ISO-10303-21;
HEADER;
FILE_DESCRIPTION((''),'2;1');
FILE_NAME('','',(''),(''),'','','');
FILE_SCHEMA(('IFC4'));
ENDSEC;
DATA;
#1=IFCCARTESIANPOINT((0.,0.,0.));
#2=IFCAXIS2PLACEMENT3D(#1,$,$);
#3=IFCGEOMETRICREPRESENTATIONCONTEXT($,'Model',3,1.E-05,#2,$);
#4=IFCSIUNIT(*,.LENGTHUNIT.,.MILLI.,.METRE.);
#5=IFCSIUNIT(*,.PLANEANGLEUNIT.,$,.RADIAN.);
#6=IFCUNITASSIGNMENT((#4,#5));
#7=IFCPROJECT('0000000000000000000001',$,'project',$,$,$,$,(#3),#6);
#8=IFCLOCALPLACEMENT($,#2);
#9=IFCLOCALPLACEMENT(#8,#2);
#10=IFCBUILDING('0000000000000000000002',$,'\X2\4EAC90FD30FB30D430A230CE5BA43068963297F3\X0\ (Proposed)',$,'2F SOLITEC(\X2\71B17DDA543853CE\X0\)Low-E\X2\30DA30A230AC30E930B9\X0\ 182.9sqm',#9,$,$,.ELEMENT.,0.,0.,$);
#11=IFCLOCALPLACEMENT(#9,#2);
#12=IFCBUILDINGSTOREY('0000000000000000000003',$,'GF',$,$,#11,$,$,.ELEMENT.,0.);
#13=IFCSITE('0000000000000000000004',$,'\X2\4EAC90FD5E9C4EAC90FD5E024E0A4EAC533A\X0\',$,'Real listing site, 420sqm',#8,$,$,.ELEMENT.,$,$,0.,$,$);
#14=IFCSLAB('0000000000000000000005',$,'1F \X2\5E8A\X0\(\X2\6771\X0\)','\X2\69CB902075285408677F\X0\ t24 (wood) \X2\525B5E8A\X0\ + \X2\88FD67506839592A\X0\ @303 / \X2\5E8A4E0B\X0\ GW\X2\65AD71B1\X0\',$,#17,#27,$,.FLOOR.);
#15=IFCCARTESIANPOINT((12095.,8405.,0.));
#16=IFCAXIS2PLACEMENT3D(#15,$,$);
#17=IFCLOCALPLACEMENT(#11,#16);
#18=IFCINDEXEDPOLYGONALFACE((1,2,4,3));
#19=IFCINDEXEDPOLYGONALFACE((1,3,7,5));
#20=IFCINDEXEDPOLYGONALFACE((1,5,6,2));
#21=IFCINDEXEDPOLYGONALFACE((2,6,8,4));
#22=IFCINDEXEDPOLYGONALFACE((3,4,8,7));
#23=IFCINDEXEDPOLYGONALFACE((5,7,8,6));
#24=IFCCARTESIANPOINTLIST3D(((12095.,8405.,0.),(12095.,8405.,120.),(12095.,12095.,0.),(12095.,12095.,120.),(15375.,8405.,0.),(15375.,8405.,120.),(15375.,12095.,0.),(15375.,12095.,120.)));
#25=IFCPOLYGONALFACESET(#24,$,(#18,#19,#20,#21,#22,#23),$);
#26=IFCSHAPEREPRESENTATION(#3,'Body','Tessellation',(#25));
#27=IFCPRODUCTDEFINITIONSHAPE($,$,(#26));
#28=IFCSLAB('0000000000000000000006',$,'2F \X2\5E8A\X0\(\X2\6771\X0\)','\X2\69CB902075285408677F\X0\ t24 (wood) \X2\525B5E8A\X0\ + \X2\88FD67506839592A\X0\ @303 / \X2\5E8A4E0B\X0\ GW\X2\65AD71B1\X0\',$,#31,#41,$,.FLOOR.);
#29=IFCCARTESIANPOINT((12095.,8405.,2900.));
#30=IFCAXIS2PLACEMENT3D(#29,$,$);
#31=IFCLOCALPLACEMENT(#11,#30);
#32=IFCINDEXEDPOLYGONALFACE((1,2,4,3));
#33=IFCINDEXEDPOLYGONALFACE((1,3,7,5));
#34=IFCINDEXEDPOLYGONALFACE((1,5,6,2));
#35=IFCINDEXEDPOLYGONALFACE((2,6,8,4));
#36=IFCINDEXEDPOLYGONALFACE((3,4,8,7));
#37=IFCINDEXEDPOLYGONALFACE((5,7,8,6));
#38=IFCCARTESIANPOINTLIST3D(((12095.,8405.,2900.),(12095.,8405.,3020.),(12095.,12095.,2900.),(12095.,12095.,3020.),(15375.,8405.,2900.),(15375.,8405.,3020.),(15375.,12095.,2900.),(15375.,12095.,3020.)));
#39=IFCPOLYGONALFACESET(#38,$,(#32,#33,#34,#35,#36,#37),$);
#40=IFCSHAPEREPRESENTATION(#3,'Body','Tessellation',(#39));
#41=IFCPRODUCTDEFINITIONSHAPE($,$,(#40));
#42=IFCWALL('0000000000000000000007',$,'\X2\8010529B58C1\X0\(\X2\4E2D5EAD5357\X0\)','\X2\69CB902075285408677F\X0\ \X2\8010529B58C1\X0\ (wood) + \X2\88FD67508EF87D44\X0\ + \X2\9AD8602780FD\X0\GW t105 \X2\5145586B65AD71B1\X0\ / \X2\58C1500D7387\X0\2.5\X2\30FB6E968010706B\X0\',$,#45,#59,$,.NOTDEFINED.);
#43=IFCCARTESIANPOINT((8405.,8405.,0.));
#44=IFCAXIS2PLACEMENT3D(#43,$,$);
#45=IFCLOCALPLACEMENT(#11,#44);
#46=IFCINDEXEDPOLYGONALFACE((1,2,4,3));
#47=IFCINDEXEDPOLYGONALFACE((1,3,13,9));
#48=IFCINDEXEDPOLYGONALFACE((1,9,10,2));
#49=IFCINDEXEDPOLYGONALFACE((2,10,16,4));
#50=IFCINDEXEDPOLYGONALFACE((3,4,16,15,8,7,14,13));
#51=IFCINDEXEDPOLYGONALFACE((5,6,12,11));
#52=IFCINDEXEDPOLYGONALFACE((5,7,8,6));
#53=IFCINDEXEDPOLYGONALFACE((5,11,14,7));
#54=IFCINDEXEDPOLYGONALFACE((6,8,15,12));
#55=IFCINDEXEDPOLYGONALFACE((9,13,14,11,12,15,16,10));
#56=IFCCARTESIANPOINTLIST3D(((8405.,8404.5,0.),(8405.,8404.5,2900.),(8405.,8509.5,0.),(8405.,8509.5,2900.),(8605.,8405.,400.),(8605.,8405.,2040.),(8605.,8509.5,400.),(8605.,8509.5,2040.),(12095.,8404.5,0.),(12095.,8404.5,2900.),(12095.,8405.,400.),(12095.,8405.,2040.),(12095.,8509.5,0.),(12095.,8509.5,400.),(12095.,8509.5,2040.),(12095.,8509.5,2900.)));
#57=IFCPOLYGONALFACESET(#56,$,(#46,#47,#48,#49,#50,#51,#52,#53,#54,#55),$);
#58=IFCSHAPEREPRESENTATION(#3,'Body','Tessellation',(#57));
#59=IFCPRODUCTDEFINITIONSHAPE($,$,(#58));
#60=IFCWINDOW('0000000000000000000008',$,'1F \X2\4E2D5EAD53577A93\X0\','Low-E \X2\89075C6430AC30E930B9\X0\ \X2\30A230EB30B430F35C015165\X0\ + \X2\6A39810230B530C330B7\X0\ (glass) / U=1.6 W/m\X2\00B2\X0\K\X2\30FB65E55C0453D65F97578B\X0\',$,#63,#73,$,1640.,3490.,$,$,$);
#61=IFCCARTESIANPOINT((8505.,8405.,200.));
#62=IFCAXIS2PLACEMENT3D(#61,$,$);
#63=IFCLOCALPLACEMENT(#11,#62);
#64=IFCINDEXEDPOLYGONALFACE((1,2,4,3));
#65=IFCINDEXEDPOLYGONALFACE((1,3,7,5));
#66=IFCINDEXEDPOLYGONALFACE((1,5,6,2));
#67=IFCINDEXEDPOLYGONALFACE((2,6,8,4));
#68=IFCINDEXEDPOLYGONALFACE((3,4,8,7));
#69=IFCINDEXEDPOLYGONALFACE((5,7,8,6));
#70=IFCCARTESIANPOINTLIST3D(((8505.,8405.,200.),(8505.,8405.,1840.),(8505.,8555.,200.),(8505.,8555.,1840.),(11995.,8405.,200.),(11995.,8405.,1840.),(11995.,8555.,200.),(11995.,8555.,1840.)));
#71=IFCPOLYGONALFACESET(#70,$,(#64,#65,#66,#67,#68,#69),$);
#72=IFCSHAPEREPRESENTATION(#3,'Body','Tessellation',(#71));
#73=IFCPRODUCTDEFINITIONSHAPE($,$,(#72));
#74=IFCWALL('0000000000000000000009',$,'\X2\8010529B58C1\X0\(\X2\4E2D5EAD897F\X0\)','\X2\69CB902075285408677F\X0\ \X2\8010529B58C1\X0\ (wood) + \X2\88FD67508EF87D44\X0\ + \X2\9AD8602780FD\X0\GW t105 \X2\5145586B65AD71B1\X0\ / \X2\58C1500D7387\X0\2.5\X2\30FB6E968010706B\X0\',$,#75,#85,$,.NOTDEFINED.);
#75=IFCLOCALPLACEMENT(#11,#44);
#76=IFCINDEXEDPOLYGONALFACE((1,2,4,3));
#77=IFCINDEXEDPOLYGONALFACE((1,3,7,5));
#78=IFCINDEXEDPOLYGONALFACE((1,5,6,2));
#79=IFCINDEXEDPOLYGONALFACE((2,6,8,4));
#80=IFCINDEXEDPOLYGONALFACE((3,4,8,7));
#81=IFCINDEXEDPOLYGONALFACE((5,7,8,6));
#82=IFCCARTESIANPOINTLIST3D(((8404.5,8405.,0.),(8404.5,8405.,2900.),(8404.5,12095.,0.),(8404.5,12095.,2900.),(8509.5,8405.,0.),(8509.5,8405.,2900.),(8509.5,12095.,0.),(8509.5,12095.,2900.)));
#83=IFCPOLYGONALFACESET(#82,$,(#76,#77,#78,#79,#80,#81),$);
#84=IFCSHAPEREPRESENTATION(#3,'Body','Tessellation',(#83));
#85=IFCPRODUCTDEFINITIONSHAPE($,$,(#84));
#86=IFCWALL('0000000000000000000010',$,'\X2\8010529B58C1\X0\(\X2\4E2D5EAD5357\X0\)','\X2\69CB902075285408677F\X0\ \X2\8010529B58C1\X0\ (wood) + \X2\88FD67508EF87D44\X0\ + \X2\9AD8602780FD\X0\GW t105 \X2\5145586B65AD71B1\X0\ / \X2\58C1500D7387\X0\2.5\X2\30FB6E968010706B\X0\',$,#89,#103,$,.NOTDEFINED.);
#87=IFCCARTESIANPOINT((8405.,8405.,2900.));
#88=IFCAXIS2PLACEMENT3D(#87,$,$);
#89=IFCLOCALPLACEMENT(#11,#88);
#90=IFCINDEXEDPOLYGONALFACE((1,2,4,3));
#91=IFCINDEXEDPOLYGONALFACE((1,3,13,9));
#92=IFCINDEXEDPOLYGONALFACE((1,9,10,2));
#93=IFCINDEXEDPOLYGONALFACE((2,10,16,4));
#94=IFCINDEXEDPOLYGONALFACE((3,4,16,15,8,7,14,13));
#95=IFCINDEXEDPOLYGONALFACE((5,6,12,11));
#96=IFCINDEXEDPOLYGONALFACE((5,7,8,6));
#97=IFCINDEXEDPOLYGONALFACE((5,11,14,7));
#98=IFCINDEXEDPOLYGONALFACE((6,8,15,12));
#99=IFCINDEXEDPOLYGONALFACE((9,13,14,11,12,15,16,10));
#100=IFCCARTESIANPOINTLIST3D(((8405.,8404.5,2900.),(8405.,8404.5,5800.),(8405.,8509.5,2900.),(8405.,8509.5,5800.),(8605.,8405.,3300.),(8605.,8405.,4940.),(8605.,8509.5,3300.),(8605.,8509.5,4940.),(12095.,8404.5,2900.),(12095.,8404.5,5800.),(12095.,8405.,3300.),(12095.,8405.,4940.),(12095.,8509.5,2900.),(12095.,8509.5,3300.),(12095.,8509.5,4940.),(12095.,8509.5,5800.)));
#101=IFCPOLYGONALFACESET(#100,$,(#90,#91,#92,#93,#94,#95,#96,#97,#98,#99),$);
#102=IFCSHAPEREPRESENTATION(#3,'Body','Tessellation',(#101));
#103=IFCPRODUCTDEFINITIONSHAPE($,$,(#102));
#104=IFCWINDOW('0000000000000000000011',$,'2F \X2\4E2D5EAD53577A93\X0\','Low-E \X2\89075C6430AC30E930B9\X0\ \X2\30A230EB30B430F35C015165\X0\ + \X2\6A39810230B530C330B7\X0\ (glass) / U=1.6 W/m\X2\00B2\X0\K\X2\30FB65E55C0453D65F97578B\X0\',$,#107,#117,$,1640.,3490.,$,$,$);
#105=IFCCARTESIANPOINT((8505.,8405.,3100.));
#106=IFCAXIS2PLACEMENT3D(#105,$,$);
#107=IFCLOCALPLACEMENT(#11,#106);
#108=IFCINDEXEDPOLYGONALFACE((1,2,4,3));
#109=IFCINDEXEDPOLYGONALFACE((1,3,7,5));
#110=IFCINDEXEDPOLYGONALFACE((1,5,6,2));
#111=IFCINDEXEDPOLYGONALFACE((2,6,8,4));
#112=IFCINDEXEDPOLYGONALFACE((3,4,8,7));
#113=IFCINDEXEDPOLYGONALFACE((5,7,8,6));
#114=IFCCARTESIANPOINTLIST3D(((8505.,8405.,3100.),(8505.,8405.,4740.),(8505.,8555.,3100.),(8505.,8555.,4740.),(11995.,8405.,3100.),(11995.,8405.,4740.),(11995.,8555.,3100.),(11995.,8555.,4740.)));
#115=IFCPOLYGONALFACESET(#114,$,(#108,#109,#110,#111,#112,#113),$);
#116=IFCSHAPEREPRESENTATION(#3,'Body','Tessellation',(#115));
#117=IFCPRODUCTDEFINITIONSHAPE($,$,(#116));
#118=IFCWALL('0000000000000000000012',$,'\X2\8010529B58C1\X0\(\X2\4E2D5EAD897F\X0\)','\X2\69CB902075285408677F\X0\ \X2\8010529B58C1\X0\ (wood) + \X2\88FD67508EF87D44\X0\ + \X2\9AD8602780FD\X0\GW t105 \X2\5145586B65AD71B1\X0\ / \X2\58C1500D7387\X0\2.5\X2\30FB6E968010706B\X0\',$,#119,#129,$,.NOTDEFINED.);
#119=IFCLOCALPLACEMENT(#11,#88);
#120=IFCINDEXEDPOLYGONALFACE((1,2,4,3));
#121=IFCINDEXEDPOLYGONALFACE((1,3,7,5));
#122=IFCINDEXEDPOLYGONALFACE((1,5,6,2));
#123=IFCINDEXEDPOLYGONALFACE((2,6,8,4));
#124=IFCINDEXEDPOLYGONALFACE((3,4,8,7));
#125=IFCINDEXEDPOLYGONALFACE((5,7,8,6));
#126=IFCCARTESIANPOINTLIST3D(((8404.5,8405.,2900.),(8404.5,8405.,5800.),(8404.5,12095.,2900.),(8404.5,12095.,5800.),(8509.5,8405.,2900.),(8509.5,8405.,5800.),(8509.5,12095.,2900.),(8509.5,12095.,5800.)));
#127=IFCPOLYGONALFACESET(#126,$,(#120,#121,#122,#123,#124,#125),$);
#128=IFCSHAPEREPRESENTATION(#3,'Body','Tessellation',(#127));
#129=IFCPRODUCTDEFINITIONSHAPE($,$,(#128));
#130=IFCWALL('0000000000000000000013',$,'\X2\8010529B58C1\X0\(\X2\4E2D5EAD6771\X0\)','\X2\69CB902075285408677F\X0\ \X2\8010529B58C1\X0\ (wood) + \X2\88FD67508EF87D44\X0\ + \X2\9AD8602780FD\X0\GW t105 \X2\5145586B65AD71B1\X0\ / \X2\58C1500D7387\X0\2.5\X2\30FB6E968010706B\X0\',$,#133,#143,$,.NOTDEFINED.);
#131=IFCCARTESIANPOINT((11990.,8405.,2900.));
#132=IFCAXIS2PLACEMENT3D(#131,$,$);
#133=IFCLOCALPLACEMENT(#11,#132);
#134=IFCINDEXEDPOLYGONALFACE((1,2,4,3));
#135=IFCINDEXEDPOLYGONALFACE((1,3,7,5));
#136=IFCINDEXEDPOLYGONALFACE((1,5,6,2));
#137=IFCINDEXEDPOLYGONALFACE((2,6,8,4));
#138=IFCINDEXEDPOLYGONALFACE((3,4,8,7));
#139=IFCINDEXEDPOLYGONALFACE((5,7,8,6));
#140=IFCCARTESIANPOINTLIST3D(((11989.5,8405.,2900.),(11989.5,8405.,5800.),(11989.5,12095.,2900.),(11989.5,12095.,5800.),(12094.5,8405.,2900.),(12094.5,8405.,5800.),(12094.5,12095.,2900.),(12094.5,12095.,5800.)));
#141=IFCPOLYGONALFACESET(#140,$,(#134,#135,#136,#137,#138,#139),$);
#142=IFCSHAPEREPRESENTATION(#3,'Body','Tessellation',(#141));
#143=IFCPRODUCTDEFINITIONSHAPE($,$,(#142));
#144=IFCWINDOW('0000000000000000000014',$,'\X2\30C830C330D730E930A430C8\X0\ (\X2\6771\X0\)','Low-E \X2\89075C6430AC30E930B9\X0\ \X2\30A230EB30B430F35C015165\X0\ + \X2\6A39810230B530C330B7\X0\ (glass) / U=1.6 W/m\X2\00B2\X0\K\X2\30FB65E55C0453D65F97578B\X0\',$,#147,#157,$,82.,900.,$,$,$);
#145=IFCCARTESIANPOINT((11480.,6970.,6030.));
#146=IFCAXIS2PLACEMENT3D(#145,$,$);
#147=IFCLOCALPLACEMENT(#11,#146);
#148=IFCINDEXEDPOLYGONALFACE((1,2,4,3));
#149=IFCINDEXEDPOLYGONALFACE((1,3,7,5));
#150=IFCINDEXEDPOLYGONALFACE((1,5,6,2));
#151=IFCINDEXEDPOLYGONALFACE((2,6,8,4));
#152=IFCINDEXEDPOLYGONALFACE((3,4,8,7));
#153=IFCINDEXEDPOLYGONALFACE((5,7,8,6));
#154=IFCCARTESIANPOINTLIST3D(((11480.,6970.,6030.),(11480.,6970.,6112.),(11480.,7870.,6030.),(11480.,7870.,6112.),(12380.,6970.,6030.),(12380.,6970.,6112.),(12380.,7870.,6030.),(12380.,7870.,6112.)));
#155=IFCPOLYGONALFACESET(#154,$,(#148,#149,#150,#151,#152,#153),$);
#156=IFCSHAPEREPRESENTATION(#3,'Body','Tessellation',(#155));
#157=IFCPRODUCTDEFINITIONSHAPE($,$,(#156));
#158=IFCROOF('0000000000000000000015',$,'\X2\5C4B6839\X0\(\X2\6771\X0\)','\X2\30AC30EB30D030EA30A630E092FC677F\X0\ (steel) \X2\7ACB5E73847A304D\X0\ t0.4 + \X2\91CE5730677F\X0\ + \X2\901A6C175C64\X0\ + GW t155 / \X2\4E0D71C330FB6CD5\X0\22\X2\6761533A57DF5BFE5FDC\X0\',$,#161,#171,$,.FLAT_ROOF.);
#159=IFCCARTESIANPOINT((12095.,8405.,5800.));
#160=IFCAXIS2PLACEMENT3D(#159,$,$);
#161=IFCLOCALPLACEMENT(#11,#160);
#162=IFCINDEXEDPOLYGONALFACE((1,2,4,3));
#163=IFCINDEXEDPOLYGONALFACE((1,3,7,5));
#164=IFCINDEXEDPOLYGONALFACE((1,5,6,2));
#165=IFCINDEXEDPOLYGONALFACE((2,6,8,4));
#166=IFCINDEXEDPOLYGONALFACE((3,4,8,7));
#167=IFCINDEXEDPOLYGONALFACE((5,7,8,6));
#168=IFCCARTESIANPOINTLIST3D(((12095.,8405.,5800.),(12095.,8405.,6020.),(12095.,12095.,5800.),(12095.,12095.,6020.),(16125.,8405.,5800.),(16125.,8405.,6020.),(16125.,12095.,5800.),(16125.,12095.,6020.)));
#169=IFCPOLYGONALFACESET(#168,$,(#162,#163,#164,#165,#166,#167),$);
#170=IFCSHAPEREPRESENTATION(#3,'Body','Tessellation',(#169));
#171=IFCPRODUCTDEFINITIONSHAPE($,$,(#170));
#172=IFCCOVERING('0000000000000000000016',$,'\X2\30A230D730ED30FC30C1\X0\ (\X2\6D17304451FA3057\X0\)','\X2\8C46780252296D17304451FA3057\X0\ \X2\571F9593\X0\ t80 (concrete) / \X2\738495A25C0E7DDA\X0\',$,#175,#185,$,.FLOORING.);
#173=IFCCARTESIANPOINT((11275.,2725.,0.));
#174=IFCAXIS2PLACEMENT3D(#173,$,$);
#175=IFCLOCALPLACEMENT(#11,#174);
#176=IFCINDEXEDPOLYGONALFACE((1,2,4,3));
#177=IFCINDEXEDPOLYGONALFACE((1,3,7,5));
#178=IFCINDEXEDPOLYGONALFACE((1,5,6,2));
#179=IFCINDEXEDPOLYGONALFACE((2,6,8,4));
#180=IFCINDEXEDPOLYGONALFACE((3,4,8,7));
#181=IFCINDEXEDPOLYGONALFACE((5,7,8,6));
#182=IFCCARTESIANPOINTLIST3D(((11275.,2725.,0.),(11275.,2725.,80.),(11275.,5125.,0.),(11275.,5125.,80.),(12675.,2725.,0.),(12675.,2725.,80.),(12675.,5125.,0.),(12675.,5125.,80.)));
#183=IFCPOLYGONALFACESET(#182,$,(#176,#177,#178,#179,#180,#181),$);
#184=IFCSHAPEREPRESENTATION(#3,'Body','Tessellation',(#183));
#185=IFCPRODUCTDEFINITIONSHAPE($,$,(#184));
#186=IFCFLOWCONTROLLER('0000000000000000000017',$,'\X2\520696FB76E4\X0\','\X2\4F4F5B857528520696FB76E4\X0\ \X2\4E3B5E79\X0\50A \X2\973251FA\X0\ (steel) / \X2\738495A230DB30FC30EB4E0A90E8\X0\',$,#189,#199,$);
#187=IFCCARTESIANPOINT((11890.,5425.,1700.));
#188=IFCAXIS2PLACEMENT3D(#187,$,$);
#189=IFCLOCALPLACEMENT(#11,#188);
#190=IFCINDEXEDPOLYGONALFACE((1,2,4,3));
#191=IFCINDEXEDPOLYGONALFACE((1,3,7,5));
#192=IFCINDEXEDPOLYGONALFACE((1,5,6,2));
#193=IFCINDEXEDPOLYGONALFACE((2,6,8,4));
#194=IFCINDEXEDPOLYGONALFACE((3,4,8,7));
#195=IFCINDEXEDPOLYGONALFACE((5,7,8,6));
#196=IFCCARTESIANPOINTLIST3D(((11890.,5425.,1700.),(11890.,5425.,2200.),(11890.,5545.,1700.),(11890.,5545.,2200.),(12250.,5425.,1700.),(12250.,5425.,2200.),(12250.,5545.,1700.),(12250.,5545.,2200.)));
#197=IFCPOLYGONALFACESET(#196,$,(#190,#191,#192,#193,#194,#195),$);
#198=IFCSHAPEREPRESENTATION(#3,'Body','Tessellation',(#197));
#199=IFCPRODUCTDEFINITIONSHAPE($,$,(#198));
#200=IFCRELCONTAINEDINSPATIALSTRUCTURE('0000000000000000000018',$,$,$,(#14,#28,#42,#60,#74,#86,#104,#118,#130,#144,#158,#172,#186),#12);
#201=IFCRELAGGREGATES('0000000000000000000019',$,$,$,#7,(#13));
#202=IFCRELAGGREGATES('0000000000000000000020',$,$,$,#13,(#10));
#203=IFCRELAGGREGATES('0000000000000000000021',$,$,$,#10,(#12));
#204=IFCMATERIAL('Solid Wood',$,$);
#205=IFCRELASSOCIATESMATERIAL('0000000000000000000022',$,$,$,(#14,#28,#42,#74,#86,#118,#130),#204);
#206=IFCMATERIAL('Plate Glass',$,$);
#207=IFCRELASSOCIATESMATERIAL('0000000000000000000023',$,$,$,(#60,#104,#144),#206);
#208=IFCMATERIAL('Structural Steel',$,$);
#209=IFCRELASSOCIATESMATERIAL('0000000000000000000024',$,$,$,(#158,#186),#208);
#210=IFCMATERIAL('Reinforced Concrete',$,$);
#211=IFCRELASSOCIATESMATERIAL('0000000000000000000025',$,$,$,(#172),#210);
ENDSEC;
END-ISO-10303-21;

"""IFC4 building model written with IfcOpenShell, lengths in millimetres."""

from ifc_helpers import new_model, si_unit, frame, frame_2d, origin, place, context, project, spatial, rectangle, extrude, material, element, fill, save


model = new_model("IFC4")

# Units and contexts
model_context = context("Model", 3, precision=1e-05, world=origin())
ifc_project = project(units=[si_unit("LENGTHUNIT", "METRE", prefix="MILLI"), si_unit("PLANEANGLEUNIT", "RADIAN")], contexts=[model_context])

# Site, building, storey
site_placement = place(None, origin())
site = spatial("IfcSite", under=ifc_project, at=site_placement, Name="京都府京都市上京区", ObjectType="Real listing site, 420sqm", CompositionType="ELEMENT", RefElevation=0.0)
building_placement = place(site_placement, origin())
building = spatial("IfcBuilding", under=site, at=building_placement, Name="京都・ピアノ室と防音 (Proposed)", ObjectType="2F SOLITEC(熱線吸収)Low-Eペアガラス 182.9sqm", CompositionType="ELEMENT", ElevationOfRefHeight=0.0, ElevationOfTerrain=0.0)
storey_placement = place(building_placement, origin())
storey = spatial("IfcBuildingStorey", under=building, at=storey_placement, Name="GF", CompositionType="ELEMENT", Elevation=0.0)

# Shared definitions
ifc_material_1 = material(Name="Solid Wood")

# Slabs
slab_1_placement = place(storey_placement, frame((12095.0, 8405.0, 0.0)))
element("IfcSlab", 1, at=slab_1_placement, inside=storey, material=ifc_material_1, Name="1F 床(東)", Description="構造用合板 t24 (wood) 剛床 + 製材根太 @303 / 床下 GW断熱", PredefinedType="FLOOR", context=model_context, shape_type="SweptSolid", body=[
    extrude(rectangle(XDim=3280.0, YDim=3690.0, at=frame_2d((1640.0, 1845.0))), frame((12095.0, 8405.0, 0.0)), (0.0, 0.0, 1.0), 120.0),
])
slab_2_placement = place(storey_placement, frame((12095.0, 8405.0, 2900.0)))
element("IfcSlab", 2, at=slab_2_placement, inside=storey, material=ifc_material_1, Name="2F 床(東)", Description="構造用合板 t24 (wood) 剛床 + 製材根太 @303 / 床下 GW断熱", PredefinedType="FLOOR", context=model_context, shape_type="SweptSolid", body=[
    extrude(rectangle(XDim=3280.0, YDim=3690.0, at=frame_2d((1640.0, 1845.0))), frame((12095.0, 8405.0, 2900.0)), (0.0, 0.0, 1.0), 120.0),
])

# Wall, opening, window
wall_1_placement = place(storey_placement, frame((8405.0, 8405.0, 0.0)))
wall_1 = element("IfcWall", 3, at=wall_1_placement, inside=storey, material=ifc_material_1, Name="耐力壁(中庭南)", Description="構造用合板 耐力壁 (wood) + 製材軸組 + 高性能GW t105 充填断熱 / 壁倍率2.5・準耐火", PredefinedType="NOTDEFINED", context=model_context, shape_type="SweptSolid", body=[
    extrude(rectangle(XDim=3690.0, YDim=105.0, at=frame_2d((1845.0, 52.0))), frame((8405.0, 8405.0, 0.0)), (0.0, 0.0, 1.0), 2900.0),
])
opening_1_placement = place(storey_placement, frame((8505.0, 8405.0, 200.0)))
opening_1 = element("IfcOpeningElement", 4, at=opening_1_placement, cuts=wall_1, PredefinedType="NOTDEFINED", context=model_context, shape_type="SweptSolid", body=[
    extrude(rectangle(XDim=3490.0, YDim=150.0, at=frame_2d((1745.0, 75.0))), frame((8505.0, 8405.0, 200.0)), (0.0, 0.0, 1.0), 1640.0),
])
ifc_material_2 = material(Name="Plate Glass")
window_1_placement = place(storey_placement, frame((8505.0, 8405.0, 200.0)))
window_1 = element("IfcWindow", 5, at=window_1_placement, inside=storey, material=ifc_material_2, Name="1F 中庭南窓", Description="Low-E 複層ガラス アルゴン封入 + 樹脂サッシ (glass) / U=1.6 W/m²K・日射取得型", OverallHeight=1640.0, OverallWidth=3490.0, context=model_context, shape_type="SweptSolid", body=[
    extrude(rectangle(XDim=3490.0, YDim=150.0, at=frame_2d((1745.0, 75.0))), frame((8505.0, 8405.0, 200.0)), (0.0, 0.0, 1.0), 1640.0),
])
fill(opening_1, window_1)

# Wall
wall_2_placement = place(storey_placement, frame((8405.0, 8405.0, 0.0)))
element("IfcWall", 6, at=wall_2_placement, inside=storey, material=ifc_material_1, Name="耐力壁(中庭西)", Description="構造用合板 耐力壁 (wood) + 製材軸組 + 高性能GW t105 充填断熱 / 壁倍率2.5・準耐火", PredefinedType="NOTDEFINED", context=model_context, shape_type="SweptSolid", body=[
    extrude(rectangle(XDim=105.0, YDim=3690.0, at=frame_2d((52.0, 1845.0))), frame((8405.0, 8405.0, 0.0)), (0.0, 0.0, 1.0), 2900.0),
])

# Wall, opening, window
wall_3_placement = place(storey_placement, frame((8405.0, 8405.0, 2900.0)))
wall_3 = element("IfcWall", 7, at=wall_3_placement, inside=storey, material=ifc_material_1, Name="耐力壁(中庭南)", Description="構造用合板 耐力壁 (wood) + 製材軸組 + 高性能GW t105 充填断熱 / 壁倍率2.5・準耐火", PredefinedType="NOTDEFINED", context=model_context, shape_type="SweptSolid", body=[
    extrude(rectangle(XDim=3690.0, YDim=105.0, at=frame_2d((1845.0, 52.0))), frame((8405.0, 8405.0, 2900.0)), (0.0, 0.0, 1.0), 2900.0),
])
opening_2_placement = place(storey_placement, frame((8505.0, 8405.0, 3100.0)))
opening_2 = element("IfcOpeningElement", 8, at=opening_2_placement, cuts=wall_3, PredefinedType="NOTDEFINED", context=model_context, shape_type="SweptSolid", body=[
    extrude(rectangle(XDim=3490.0, YDim=150.0, at=frame_2d((1745.0, 75.0))), frame((8505.0, 8405.0, 3100.0)), (0.0, 0.0, 1.0), 1640.0),
])
window_2_placement = place(storey_placement, frame((8505.0, 8405.0, 3100.0)))
window_2 = element("IfcWindow", 9, at=window_2_placement, inside=storey, material=ifc_material_2, Name="2F 中庭南窓", Description="Low-E 複層ガラス アルゴン封入 + 樹脂サッシ (glass) / U=1.6 W/m²K・日射取得型", OverallHeight=1640.0, OverallWidth=3490.0, context=model_context, shape_type="SweptSolid", body=[
    extrude(rectangle(XDim=3490.0, YDim=150.0, at=frame_2d((1745.0, 75.0))), frame((8505.0, 8405.0, 3100.0)), (0.0, 0.0, 1.0), 1640.0),
])
fill(opening_2, window_2)

# Walls
wall_4_placement = place(storey_placement, frame((8405.0, 8405.0, 2900.0)))
element("IfcWall", 10, at=wall_4_placement, inside=storey, material=ifc_material_1, Name="耐力壁(中庭西)", Description="構造用合板 耐力壁 (wood) + 製材軸組 + 高性能GW t105 充填断熱 / 壁倍率2.5・準耐火", PredefinedType="NOTDEFINED", context=model_context, shape_type="SweptSolid", body=[
    extrude(rectangle(XDim=105.0, YDim=3690.0, at=frame_2d((52.0, 1845.0))), frame((8405.0, 8405.0, 2900.0)), (0.0, 0.0, 1.0), 2900.0),
])
wall_5_placement = place(storey_placement, frame((11990.0, 8405.0, 2900.0)))
element("IfcWall", 11, at=wall_5_placement, inside=storey, material=ifc_material_1, Name="耐力壁(中庭東)", Description="構造用合板 耐力壁 (wood) + 製材軸組 + 高性能GW t105 充填断熱 / 壁倍率2.5・準耐火", PredefinedType="NOTDEFINED", context=model_context, shape_type="SweptSolid", body=[
    extrude(rectangle(XDim=105.0, YDim=3690.0, at=frame_2d((52.0, 1845.0))), frame((11990.0, 8405.0, 2900.0)), (0.0, 0.0, 1.0), 2900.0),
])

# Window
window_3_placement = place(storey_placement, frame((11480.0, 6970.0, 6030.0)))
element("IfcWindow", 12, at=window_3_placement, inside=storey, material=ifc_material_2, Name="トップライト (東)", Description="Low-E 複層ガラス アルゴン封入 + 樹脂サッシ (glass) / U=1.6 W/m²K・日射取得型", OverallHeight=82.0, OverallWidth=900.0, context=model_context, shape_type="SweptSolid", body=[
    extrude(rectangle(XDim=900.0, YDim=900.0, at=frame_2d((450.0, 450.0))), frame((11480.0, 6970.0, 6030.0)), (0.0, 0.0, 1.0), 82.0),
])

# Roof
ifc_material_3 = material(Name="Structural Steel")
for number, where, name in (
    (13, (12095.0, 8405.0, 5800.0), "屋根(東)"),
):
    element("IfcRoof", number, at=place(storey_placement, frame(where)), inside=storey, material=ifc_material_3, Name=name, Description="ガルバリウム鋼板 (steel) 立平葺き t0.4 + 野地板 + 通気層 + GW t155 / 不燃・法22条区域対応", PredefinedType="FLAT_ROOF", context=model_context, shape_type="SweptSolid", body=[
        extrude(rectangle(XDim=4030.0, YDim=3690.0, at=frame_2d((2015.0, 1845.0))), frame((12095.0, 8405.0, 5800.0)), (0.0, 0.0, 1.0), 220.0),
    ])

# Covering
ifc_material_4 = material(Name="Reinforced Concrete")
covering_placement = place(storey_placement, frame((11275.0, 2725.0, 0.0)))
element("IfcCovering", 14, at=covering_placement, inside=storey, material=ifc_material_4, Name="アプローチ (洗い出し)", Description="豆砂利洗い出し 土間 t80 (concrete) / 玄関導線", PredefinedType="FLOORING", context=model_context, shape_type="SweptSolid", body=[
    extrude(rectangle(XDim=1400.0, YDim=2400.0, at=frame_2d((700.0, 1200.0))), frame((11275.0, 2725.0, 0.0)), (0.0, 0.0, 1.0), 80.0),
])

# Flow controller
flow_controller_placement = place(storey_placement, frame((11890.0, 5425.0, 1700.0)))
element("IfcFlowController", 15, at=flow_controller_placement, inside=storey, material=ifc_material_3, Name="分電盤", Description="住宅用分電盤 主幹50A 露出 (steel) / 玄関ホール上部", context=model_context, shape_type="SweptSolid", body=[
    extrude(rectangle(XDim=360.0, YDim=120.0, at=frame_2d((180.0, 60.0))), frame((11890.0, 5425.0, 1700.0)), (0.0, 0.0, 1.0), 500.0),
])

save(model, "model.ifc")
